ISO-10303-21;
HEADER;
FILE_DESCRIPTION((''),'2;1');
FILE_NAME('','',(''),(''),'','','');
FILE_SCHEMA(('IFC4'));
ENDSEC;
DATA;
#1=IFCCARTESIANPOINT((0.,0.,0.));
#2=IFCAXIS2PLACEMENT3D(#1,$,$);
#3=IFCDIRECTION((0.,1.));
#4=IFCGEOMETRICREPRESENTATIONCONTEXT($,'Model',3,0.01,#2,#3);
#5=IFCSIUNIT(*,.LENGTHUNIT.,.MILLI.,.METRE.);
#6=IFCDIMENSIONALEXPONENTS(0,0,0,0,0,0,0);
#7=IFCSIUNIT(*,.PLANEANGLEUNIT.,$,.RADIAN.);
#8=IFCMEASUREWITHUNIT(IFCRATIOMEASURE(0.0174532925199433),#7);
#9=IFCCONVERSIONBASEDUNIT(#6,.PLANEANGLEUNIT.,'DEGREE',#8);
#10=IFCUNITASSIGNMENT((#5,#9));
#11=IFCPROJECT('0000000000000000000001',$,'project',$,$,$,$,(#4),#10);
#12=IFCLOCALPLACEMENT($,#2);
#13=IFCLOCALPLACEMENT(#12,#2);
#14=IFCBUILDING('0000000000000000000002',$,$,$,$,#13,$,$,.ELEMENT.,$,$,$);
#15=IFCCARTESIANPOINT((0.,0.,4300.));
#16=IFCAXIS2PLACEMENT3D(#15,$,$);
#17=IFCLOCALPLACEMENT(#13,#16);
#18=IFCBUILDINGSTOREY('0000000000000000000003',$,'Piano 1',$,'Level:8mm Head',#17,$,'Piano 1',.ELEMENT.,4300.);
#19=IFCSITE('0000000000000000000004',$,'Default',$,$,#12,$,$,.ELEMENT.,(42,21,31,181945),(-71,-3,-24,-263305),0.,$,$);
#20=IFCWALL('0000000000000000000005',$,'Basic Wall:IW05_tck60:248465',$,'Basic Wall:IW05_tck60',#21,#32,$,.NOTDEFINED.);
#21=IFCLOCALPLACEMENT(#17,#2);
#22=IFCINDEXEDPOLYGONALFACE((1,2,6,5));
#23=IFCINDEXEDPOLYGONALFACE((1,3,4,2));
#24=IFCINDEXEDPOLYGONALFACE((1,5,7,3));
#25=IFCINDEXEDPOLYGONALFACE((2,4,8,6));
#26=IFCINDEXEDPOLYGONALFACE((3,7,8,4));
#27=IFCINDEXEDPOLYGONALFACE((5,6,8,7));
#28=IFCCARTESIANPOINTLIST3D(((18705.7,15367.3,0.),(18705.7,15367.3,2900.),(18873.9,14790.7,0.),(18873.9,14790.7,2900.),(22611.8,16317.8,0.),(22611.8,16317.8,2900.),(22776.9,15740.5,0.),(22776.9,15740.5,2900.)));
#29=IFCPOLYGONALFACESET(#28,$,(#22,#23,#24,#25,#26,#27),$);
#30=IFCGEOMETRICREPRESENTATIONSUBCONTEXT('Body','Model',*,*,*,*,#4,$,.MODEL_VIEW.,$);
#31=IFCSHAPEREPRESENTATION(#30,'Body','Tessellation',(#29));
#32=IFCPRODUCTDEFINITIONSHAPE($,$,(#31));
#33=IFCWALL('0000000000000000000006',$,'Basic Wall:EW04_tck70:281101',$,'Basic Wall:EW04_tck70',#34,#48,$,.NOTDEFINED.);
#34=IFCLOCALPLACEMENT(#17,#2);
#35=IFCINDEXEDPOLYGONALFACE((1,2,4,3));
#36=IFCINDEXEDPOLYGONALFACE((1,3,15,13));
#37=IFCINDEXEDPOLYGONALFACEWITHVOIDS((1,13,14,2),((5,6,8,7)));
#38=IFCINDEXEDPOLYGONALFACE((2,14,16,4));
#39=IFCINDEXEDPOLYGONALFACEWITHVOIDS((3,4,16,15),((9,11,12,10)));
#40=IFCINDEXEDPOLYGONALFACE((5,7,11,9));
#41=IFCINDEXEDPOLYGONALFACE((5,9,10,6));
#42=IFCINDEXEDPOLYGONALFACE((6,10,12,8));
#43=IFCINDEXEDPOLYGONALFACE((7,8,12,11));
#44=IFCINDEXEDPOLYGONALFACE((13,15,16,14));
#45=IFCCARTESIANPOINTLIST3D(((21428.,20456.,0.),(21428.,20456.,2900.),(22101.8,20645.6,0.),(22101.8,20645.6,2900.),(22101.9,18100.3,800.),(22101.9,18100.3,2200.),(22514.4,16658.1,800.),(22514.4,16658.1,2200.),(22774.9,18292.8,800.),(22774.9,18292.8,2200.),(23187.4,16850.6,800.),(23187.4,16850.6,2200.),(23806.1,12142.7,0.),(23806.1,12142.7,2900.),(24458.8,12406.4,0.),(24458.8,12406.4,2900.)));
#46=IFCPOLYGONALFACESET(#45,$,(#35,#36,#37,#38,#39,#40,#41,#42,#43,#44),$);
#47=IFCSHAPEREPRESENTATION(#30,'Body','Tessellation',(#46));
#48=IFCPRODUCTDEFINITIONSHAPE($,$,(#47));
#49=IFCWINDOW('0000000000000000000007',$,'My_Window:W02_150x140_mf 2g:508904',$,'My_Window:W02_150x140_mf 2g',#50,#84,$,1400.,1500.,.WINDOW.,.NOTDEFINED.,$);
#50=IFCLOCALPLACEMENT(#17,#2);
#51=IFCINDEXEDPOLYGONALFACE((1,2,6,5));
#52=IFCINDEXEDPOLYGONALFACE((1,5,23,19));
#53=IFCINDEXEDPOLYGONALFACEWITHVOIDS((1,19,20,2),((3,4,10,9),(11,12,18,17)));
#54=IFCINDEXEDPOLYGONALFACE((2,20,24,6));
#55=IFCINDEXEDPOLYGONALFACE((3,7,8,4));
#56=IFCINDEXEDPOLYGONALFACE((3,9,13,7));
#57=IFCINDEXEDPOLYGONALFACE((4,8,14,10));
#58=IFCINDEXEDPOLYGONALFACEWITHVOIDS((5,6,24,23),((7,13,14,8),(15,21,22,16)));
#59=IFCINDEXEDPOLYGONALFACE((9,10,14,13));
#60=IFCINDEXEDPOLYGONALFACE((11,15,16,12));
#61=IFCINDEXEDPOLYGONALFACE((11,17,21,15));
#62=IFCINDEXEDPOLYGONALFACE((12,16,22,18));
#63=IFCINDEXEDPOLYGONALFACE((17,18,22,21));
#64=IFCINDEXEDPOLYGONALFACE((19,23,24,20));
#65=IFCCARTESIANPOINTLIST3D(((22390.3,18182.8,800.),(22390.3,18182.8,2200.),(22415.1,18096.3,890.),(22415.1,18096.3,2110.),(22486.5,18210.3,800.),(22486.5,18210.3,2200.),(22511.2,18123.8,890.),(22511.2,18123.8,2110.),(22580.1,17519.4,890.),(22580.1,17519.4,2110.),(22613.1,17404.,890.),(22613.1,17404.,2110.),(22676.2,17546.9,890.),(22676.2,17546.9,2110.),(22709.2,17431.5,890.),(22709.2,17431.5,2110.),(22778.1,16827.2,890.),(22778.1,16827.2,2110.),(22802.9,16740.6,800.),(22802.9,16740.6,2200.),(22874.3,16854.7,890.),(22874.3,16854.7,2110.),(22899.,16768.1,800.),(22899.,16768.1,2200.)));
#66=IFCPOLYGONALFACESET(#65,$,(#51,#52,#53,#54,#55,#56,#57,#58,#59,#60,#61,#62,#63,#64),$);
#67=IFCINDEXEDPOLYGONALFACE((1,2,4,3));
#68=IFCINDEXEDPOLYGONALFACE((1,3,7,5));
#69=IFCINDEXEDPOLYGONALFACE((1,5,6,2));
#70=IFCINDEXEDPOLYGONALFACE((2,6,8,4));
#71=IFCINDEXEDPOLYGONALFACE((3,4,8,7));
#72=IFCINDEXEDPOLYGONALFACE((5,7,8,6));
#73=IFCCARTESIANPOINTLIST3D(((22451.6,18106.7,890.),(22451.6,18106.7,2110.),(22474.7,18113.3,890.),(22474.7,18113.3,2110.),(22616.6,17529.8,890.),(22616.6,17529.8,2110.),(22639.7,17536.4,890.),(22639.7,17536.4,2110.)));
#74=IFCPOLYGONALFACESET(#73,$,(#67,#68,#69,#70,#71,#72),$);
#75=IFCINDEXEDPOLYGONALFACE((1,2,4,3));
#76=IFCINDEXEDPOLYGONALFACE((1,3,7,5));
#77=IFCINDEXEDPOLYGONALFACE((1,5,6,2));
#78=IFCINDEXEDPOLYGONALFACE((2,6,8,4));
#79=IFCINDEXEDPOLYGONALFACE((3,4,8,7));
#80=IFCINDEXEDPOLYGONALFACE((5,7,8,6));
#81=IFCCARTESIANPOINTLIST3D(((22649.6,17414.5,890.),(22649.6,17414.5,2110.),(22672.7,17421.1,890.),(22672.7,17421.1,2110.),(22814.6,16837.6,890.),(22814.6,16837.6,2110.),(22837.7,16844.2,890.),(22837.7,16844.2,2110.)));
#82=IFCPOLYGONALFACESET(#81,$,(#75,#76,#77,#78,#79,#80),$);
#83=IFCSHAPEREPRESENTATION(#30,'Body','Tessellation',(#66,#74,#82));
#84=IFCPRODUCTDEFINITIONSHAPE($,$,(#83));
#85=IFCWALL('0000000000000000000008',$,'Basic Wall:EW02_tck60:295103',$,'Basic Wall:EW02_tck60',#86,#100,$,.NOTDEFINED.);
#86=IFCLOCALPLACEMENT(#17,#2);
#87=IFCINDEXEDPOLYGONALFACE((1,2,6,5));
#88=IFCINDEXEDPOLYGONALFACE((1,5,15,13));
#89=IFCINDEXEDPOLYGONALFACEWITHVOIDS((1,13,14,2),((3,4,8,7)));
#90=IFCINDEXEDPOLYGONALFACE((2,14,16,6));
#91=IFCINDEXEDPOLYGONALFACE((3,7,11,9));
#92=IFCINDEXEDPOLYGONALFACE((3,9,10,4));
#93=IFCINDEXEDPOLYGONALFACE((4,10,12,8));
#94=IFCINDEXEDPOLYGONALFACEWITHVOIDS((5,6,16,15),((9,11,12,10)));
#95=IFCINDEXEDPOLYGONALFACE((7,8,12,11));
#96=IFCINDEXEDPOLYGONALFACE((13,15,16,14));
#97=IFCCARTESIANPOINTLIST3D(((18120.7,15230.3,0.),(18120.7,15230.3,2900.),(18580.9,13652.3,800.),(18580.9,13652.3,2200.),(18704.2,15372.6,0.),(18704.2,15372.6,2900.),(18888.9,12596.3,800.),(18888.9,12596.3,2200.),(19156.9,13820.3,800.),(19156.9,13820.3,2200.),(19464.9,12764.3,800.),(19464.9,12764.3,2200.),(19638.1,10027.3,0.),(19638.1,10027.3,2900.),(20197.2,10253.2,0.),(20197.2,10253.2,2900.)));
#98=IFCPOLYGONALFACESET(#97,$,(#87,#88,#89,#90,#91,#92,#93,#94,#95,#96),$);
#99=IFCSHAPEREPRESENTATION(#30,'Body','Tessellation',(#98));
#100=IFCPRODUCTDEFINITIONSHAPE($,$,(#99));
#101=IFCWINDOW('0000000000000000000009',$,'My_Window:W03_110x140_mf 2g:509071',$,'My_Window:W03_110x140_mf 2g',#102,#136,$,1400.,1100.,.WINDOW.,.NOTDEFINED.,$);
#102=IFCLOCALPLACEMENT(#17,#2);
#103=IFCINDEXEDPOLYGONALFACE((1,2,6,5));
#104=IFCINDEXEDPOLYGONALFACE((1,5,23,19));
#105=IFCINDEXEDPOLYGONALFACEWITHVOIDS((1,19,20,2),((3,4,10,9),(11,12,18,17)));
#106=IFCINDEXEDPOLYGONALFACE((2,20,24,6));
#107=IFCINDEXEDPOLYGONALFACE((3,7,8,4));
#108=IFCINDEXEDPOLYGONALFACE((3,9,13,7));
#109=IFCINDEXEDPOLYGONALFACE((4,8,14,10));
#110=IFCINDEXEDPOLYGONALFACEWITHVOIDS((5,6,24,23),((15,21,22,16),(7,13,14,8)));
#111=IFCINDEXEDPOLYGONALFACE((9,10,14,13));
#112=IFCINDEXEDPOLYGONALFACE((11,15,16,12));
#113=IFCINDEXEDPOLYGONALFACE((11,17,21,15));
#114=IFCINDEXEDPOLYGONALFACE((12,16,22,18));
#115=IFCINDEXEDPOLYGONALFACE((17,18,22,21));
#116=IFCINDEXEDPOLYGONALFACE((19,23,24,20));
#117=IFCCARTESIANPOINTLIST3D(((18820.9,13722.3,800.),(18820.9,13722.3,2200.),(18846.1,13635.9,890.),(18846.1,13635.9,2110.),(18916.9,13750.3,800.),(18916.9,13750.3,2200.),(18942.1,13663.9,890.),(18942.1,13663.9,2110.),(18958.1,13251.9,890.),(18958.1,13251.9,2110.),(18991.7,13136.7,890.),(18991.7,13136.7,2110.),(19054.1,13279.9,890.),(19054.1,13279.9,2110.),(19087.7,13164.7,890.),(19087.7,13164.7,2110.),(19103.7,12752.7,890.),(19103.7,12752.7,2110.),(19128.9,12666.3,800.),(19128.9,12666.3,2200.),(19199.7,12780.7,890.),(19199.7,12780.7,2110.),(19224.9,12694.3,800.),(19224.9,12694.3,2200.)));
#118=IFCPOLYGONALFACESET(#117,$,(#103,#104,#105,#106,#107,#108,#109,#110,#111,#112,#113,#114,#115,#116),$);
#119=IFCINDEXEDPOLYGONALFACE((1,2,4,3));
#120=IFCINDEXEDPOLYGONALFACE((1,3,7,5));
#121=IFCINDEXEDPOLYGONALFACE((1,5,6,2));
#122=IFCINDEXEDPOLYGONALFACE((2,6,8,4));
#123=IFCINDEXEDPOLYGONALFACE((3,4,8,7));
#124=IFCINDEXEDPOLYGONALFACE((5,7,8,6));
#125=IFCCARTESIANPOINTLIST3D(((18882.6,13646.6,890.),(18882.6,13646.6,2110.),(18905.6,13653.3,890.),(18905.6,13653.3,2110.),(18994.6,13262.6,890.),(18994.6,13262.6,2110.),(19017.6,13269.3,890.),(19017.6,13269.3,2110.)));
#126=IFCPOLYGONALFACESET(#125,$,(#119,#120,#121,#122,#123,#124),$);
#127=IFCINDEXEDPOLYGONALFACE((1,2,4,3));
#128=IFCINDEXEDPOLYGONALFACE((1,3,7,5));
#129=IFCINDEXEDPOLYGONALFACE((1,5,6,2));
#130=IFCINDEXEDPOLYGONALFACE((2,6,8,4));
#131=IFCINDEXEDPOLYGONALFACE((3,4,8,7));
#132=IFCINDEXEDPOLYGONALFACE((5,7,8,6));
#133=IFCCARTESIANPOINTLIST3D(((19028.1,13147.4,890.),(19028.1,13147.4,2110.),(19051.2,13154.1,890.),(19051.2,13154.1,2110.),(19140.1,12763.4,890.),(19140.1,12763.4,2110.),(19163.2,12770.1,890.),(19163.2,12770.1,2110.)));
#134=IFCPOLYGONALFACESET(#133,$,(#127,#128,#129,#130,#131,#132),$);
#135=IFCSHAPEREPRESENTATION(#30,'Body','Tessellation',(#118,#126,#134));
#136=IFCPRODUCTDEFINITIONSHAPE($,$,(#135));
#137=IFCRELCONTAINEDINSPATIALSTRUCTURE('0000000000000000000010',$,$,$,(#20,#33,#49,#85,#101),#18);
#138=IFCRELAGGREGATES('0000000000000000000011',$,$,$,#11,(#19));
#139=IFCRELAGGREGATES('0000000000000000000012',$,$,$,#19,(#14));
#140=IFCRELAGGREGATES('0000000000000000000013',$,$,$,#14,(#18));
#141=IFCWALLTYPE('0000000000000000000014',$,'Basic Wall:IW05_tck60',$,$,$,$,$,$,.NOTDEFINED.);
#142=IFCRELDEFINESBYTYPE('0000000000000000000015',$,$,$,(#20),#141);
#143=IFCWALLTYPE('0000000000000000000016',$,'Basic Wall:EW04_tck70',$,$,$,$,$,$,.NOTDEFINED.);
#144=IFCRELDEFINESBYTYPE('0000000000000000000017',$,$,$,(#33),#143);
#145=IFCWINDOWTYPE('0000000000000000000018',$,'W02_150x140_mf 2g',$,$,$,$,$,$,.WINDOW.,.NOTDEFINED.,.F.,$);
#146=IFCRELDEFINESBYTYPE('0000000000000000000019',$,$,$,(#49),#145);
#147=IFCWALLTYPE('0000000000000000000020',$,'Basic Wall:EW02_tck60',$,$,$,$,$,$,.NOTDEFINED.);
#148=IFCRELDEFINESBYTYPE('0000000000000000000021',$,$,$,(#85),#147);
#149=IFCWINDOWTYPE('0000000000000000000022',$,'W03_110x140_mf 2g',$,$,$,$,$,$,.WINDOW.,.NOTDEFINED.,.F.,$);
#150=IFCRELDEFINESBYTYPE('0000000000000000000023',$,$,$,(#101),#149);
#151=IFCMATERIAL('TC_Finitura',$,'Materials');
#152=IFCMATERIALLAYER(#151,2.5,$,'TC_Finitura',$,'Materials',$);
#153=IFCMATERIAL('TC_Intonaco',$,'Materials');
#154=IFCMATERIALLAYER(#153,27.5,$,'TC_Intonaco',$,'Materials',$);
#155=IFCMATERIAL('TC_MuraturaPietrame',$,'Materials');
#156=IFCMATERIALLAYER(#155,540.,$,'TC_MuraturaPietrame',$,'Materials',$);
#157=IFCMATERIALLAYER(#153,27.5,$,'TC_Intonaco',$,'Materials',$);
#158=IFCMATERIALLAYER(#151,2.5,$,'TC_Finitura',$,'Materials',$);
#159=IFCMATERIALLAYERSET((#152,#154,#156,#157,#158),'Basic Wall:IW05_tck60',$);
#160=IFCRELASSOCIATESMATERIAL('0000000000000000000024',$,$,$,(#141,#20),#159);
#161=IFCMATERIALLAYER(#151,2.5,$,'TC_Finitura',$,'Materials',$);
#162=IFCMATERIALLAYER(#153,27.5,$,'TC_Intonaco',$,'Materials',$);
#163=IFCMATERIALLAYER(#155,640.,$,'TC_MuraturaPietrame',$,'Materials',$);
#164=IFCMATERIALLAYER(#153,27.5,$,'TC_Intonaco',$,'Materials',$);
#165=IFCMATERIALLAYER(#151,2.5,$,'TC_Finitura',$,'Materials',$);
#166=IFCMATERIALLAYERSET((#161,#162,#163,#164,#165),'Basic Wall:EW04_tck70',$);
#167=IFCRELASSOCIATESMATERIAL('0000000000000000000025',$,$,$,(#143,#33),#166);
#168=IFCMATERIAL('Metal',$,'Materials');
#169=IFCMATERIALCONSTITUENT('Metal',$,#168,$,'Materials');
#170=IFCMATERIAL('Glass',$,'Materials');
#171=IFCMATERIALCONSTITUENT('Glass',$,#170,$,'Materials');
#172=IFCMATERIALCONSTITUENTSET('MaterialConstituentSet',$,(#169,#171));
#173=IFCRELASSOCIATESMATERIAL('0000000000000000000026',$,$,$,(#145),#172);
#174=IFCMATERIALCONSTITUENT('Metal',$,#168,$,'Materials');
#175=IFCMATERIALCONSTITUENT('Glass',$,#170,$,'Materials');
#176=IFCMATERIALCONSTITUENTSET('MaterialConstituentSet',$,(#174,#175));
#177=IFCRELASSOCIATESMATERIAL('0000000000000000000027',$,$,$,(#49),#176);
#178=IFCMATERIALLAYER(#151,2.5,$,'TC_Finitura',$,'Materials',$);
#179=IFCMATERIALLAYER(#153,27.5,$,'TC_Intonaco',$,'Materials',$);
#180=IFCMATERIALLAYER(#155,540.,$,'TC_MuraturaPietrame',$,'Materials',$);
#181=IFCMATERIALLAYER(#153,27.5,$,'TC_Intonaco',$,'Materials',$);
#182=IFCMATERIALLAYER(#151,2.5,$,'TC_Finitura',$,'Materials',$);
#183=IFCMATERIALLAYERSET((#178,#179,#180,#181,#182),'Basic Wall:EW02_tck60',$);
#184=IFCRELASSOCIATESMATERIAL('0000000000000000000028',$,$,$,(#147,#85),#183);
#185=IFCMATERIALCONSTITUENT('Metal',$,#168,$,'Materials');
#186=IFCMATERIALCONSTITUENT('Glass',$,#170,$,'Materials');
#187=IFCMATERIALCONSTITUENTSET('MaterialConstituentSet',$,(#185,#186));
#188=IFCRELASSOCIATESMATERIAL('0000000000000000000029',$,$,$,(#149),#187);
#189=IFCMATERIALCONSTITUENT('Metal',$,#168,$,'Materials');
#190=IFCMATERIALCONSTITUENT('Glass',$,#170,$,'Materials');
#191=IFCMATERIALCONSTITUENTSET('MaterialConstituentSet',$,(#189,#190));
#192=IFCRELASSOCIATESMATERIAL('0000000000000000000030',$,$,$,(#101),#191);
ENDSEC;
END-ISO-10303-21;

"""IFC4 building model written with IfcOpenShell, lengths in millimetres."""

from ifc_helpers import new_model, entity, si_unit, converted_unit, direction, frame, frame_2d, origin, origin_2d_with_axis, place, context, subcontext, project, spatial, polyline, rectangle, outline, extrude, clip, bounded_halfspace, source, transform, mapped, material, layer, layer_set, layer_usage, constituent, constituent_set, type_object, type_shapes, element, fill, save


model = new_model("IFC4")

# Units and contexts
model_context = context("Model", 3, precision=0.01, world=origin(), true_north=direction((0.0, 1.0)))
body_context = subcontext(model_context, "Body", "Model", "MODEL_VIEW")
ifc_project = project(units=[si_unit("LENGTHUNIT", "METRE", prefix="MILLI"), converted_unit("PLANEANGLEUNIT", "DEGREE", entity("IfcRatioMeasure", 0.0174532925199433), si_unit("PLANEANGLEUNIT", "RADIAN"), dimensions=[0, 0, 0, 0, 0, 0, 0])], contexts=[model_context])

# Site, building, storey
site_placement = place(None, origin())
site = spatial("IfcSite", under=ifc_project, at=site_placement, Name="Default", CompositionType="ELEMENT", RefLatitude=(42, 21, 31, 181945), RefLongitude=(-71, -3, -24, -263305), RefElevation=0.0)
building_placement = place(site_placement, origin())
building = spatial("IfcBuilding", under=site, at=building_placement, CompositionType="ELEMENT")
storey_placement = place(building_placement, frame((0.0, 0.0, 4300.0)))
storey = spatial("IfcBuildingStorey", under=building, at=storey_placement, Name="Piano 1", ObjectType="Level:8mm Head", LongName="Piano 1", CompositionType="ELEMENT", Elevation=4300.0)

# Wall
ifc_material_1 = material(Name="TC_Finitura", Category="Materials")
ifc_layer_1 = layer(ifc_material_1, 2.5, Name="TC_Finitura", Category="Materials")
ifc_material_2 = material(Name="TC_Intonaco", Category="Materials")
ifc_layer_2 = layer(ifc_material_2, 27.5, Name="TC_Intonaco", Category="Materials")
ifc_material_3 = material(Name="TC_MuraturaPietrame", Category="Materials")
ifc_layer_3 = layer(ifc_material_3, 540.0, Name="TC_MuraturaPietrame", Category="Materials")
ifc_layer_4 = layer(ifc_material_2, 27.5, Name="TC_Intonaco", Category="Materials")
ifc_layer_5 = layer(ifc_material_1, 2.5, Name="TC_Finitura", Category="Materials")
ifc_layer_set_1 = layer_set([ifc_layer_1, ifc_layer_2, ifc_layer_3, ifc_layer_4, ifc_layer_5], Name="Basic Wall:IW05_tck60")
ifc_layer_usage_1 = layer_usage(ifc_layer_set_1, "AXIS2", "NEGATIVE", 300.0)
wall_type_1 = type_object("IfcWallType", Name="Basic Wall:IW05_tck60", PredefinedType="NOTDEFINED", material=ifc_layer_set_1)
wall_1_placement = place(storey_placement, frame((22706.0, 16032.0, 0.0), z_axis=(0.0, 0.0, 1.0), x_axis=(-0.971642, -0.236458, 0.0)))
element("IfcWall", 1, at=wall_1_placement, inside=storey, type_object=wall_type_1, material=ifc_layer_usage_1, Name="Basic Wall:IW05_tck60:248465", ObjectType="Basic Wall:IW05_tck60", PredefinedType="NOTDEFINED", context=body_context, shape_type="Clipping", body=[
    clip(extrude(outline(polyline([(4044.0, -300.0), (4016.9, 300.0), (0.0, 300.0), (24.0, -300.0), (4044.0, -300.0)])), origin(), (0.0, 0.0, 1.0), 2900.0), bounded_halfspace(frame((24.0, -300.0, 2900.0), z_axis=(0.0, 0.0, -1.0), x_axis=(-0.999371, -0.035464, 0.0)), True, frame((24.0, -300.0, 2900.0)), polyline([(0.0, 0.0), (4020.0, 0.0), (3993.0, 600.0), (-24.0, 600.0), (0.0, 0.0)]))),
])

# Walls, openings, windows
ifc_layer_6 = layer(ifc_material_1, 2.5, Name="TC_Finitura", Category="Materials")
ifc_layer_7 = layer(ifc_material_2, 27.5, Name="TC_Intonaco", Category="Materials")
ifc_layer_8 = layer(ifc_material_3, 640.0, Name="TC_MuraturaPietrame", Category="Materials")
ifc_layer_9 = layer(ifc_material_2, 27.5, Name="TC_Intonaco", Category="Materials")
ifc_layer_10 = layer(ifc_material_1, 2.5, Name="TC_Finitura", Category="Materials")
ifc_layer_set_2 = layer_set([ifc_layer_6, ifc_layer_7, ifc_layer_8, ifc_layer_9, ifc_layer_10], Name="Basic Wall:EW04_tck70")
ifc_layer_usage_2 = layer_usage(ifc_layer_set_2, "AXIS2", "NEGATIVE", 350.0)
wall_type_2 = type_object("IfcWallType", Name="Basic Wall:EW04_tck70", PredefinedType="NOTDEFINED", material=ifc_layer_set_2)
wall_2_placement = place(storey_placement, frame((24142.6, 12239.0, 0.0), z_axis=(0.0, 0.0, 1.0), x_axis=(-0.275033, 0.961435, 0.0)))
wall_2 = element("IfcWall", 2, at=wall_2_placement, inside=storey, type_object=wall_type_2, material=ifc_layer_usage_2, Name="Basic Wall:EW04_tck70:281101", ObjectType="Basic Wall:EW04_tck70", PredefinedType="NOTDEFINED", context=body_context, shape_type="Clipping", body=[
    clip(extrude(outline(polyline([(8643.6, -350.0), (8646.7, 350.0), (8246.7, 350.0), (4342.6, 350.0), (3742.1, 350.0), (0.0, 350.0), (74.0, -350.0), (8643.6, -350.0)])), origin(), (0.0, 0.0, 1.0), 2900.0), bounded_halfspace(frame((74.0, -350.0, 2900.0), z_axis=(0.0, 0.0, -1.0), x_axis=(-0.004433, -0.99999, 0.0)), True, frame((74.0, -350.0, 2900.0)), polyline([(0.0, 0.0), (8569.6, 0.0), (8572.7, 700.0), (8172.7, 700.0), (4268.6, 700.0), (3668.1, 700.0), (-74.0, 700.0), (0.0, 0.0)]))),
])
opening_1_placement = place(wall_2_placement, frame((6196.5, 350.0, 800.0)))
opening_1 = element("IfcOpeningElement", 3, at=opening_1_placement, cuts=wall_2, ObjectType="Opening", PredefinedType="OPENING", context=body_context, shape_type="SweptSolid", body=[
    extrude(rectangle(XDim=1400.0, YDim=1500.0, at=frame_2d((700.0, 750.0), x_axis=(-1.0, 0.0))), frame((0.0, 0.0, 0.0), z_axis=(0.0, -1.0, 0.0), x_axis=(0.0, 0.0, 1.0)), (0.0, 0.0, 1.0), 700.0),
])
ifc_material_4 = material(Name="Metal", Category="Materials")
ifc_constituent_1 = constituent(ifc_material_4, Name="Metal", Category="Materials")
ifc_material_5 = material(Name="Glass", Category="Materials")
ifc_constituent_2 = constituent(ifc_material_5, Name="Glass", Category="Materials")
ifc_constituent_set_1 = constituent_set(constituents=[ifc_constituent_1, ifc_constituent_2], Name="MaterialConstituentSet")
ifc_constituent_3 = constituent(ifc_material_4, Name="Metal", Category="Materials")
ifc_constituent_4 = constituent(ifc_material_5, Name="Glass", Category="Materials")
ifc_constituent_set_2 = constituent_set(constituents=[ifc_constituent_3, ifc_constituent_4], Name="MaterialConstituentSet")
window_type_1 = type_object("IfcWindowType", Name="W02_150x140_mf 2g", ParameterTakesPrecedence=False, PartitioningType="NOTDEFINED", PredefinedType="WINDOW", material=ifc_constituent_set_2)
shared_shape_1 = source(origin(), body_context, "Body", "SweptSolid", [
    extrude(outline(polyline([(-750.0, -700.0), (750.0, -700.0), (750.0, 700.0), (-750.0, 700.0), (-750.0, -700.0)]), holes=[polyline([(-60.0, -610.0), (-660.0, -610.0), (-660.0, 610.0), (-60.0, 610.0), (-60.0, -610.0)]), polyline([(660.0, -610.0), (60.0, -610.0), (60.0, 610.0), (660.0, 610.0), (660.0, -610.0)])]), frame((750.0, 300.0, 700.0), z_axis=(0.0, 1.0, 0.0), x_axis=(1.0, 0.0, 0.0)), (0.0, 0.0, 1.0), 100.0),
    extrude(rectangle(XDim=24.0, YDim=600.0, at=origin_2d_with_axis()), frame((390.0, 350.0, 90.0), z_axis=(0.0, 0.0, 1.0), x_axis=(0.0, 1.0, 0.0)), (0.0, 0.0, 1.0), 1220.0),
    extrude(rectangle(XDim=24.0, YDim=600.0, at=frame_2d((0.0, 0.0), x_axis=(1.0, 0.0))), frame((1110.0, 350.0, 90.0), z_axis=(0.0, 0.0, 1.0), x_axis=(0.0, 1.0, 0.0)), (0.0, 0.0, 1.0), 1220.0),
])
type_shapes(window_type_1, [shared_shape_1])
window_1_placement = place(opening_1_placement, frame((0.0, 0.0, 0.0), z_axis=(0.0, 0.0, 1.0), x_axis=(-1.0, 0.0, 0.0)))
window_1 = element("IfcWindow", 4, at=window_1_placement, inside=storey, type_object=window_type_1, material=ifc_constituent_set_1, Name="My_Window:W02_150x140_mf 2g:508904", ObjectType="My_Window:W02_150x140_mf 2g", OverallHeight=1400.0, OverallWidth=1500.0, PartitioningType="NOTDEFINED", PredefinedType="WINDOW", context=body_context, shape_type="MappedRepresentation", body=[
    mapped(shared_shape_1, transform((0.0, 0.0, 0.0), scale=1.0)),
])
fill(opening_1, window_1)
ifc_layer_11 = layer(ifc_material_1, 2.5, Name="TC_Finitura", Category="Materials")
ifc_layer_12 = layer(ifc_material_2, 27.5, Name="TC_Intonaco", Category="Materials")
ifc_layer_13 = layer(ifc_material_3, 540.0, Name="TC_MuraturaPietrame", Category="Materials")
ifc_layer_14 = layer(ifc_material_2, 27.5, Name="TC_Intonaco", Category="Materials")
ifc_layer_15 = layer(ifc_material_1, 2.5, Name="TC_Finitura", Category="Materials")
ifc_layer_set_3 = layer_set([ifc_layer_11, ifc_layer_12, ifc_layer_13, ifc_layer_14, ifc_layer_15], Name="Basic Wall:EW02_tck60")
ifc_layer_usage_3 = layer_usage(ifc_layer_set_3, "AXIS2", "POSITIVE", -300.0)
wall_type_3 = type_object("IfcWallType", Name="Basic Wall:EW02_tck60", PredefinedType="NOTDEFINED", material=ifc_layer_set_3)
wall_3_placement = place(storey_placement, frame((18408.7, 15314.3, 0.0), z_axis=(0.0, 0.0, 1.0), x_axis=(0.279974, -0.960008, 0.0)))
wall_3 = element("IfcWall", 5, at=wall_3_placement, inside=storey, type_object=wall_type_3, material=ifc_layer_usage_3, Name="Basic Wall:EW02_tck60:295103", ObjectType="Basic Wall:EW02_tck60", PredefinedType="NOTDEFINED", context=body_context, shape_type="Clipping", body=[
    clip(extrude(outline(polyline([(5419.7, -300.0), (5359.4, 300.0), (4957.4, 300.0), (632.9, 300.0), (32.3, 300.0), (26.7, 300.0), (24.2, 243.1), (1.9, -256.7), (0.0, -300.0), (600.6, -300.0), (5012.3, -300.0), (5419.7, -300.0)])), origin(), (0.0, 0.0, 1.0), 2900.0), bounded_halfspace(frame((0.0, -300.0, 2900.0), z_axis=(0.0, 0.0, -1.0), x_axis=(0.009577, 0.999954, 0.0)), True, frame((0.0, -300.0, 2900.0)), polyline([(0.0, 0.0), (600.6, 0.0), (602.5, 0.0), (5012.3, 0.0), (5419.7, 0.0), (5359.4, 600.0), (4957.4, 600.0), (632.9, 600.0), (32.3, 600.0), (26.7, 600.0), (24.2, 543.1), (1.9, 43.3), (0.0, 0.0)]))),
])
opening_2_placement = place(wall_3_placement, frame((1643.7, -300.0, 800.0)))
opening_2 = element("IfcOpeningElement", 6, at=opening_2_placement, cuts=wall_3, ObjectType="Opening", PredefinedType="OPENING", context=body_context, shape_type="SweptSolid", body=[
    extrude(rectangle(XDim=1400.0, YDim=1100.0, at=frame_2d((700.0, 550.0), x_axis=(-1.0, 0.0))), frame((0.0, 0.0, 0.0), z_axis=(0.0, 1.0, 0.0), x_axis=(0.0, 0.0, 1.0)), (0.0, 0.0, 1.0), 600.0),
])
ifc_constituent_5 = constituent(ifc_material_4, Name="Metal", Category="Materials")
ifc_constituent_6 = constituent(ifc_material_5, Name="Glass", Category="Materials")
ifc_constituent_set_3 = constituent_set(constituents=[ifc_constituent_5, ifc_constituent_6], Name="MaterialConstituentSet")
ifc_constituent_7 = constituent(ifc_material_4, Name="Metal", Category="Materials")
ifc_constituent_8 = constituent(ifc_material_5, Name="Glass", Category="Materials")
ifc_constituent_set_4 = constituent_set(constituents=[ifc_constituent_7, ifc_constituent_8], Name="MaterialConstituentSet")
window_type_2 = type_object("IfcWindowType", Name="W03_110x140_mf 2g", ParameterTakesPrecedence=False, PartitioningType="NOTDEFINED", PredefinedType="WINDOW", material=ifc_constituent_set_4)
shared_shape_2 = source(origin(), body_context, "Body", "SweptSolid", [
    extrude(outline(polyline([(-550.0, -700.0), (550.0, -700.0), (550.0, 700.0), (-550.0, 700.0), (-550.0, -700.0)]), holes=[polyline([(-60.0, -610.0), (-460.0, -610.0), (-460.0, 610.0), (-60.0, 610.0), (-60.0, -610.0)]), polyline([(460.0, -610.0), (60.0, -610.0), (60.0, 610.0), (460.0, 610.0), (460.0, -610.0)])]), frame((550.0, 250.0, 700.0), z_axis=(0.0, 1.0, 0.0), x_axis=(1.0, 0.0, 0.0)), (0.0, 0.0, 1.0), 100.0),
    extrude(rectangle(XDim=24.0, YDim=400.0, at=origin_2d_with_axis()), frame((290.0, 300.0, 90.0), z_axis=(0.0, 0.0, 1.0), x_axis=(0.0, 1.0, 0.0)), (0.0, 0.0, 1.0), 1220.0),
    extrude(rectangle(XDim=24.0, YDim=400.0, at=frame_2d((0.0, 0.0), x_axis=(1.0, 0.0))), frame((810.0, 300.0, 90.0), z_axis=(0.0, 0.0, 1.0), x_axis=(0.0, 1.0, 0.0)), (0.0, 0.0, 1.0), 1220.0),
])
type_shapes(window_type_2, [shared_shape_2])
window_2_placement = place(opening_2_placement, origin())
window_2 = element("IfcWindow", 7, at=window_2_placement, inside=storey, type_object=window_type_2, material=ifc_constituent_set_3, Name="My_Window:W03_110x140_mf 2g:509071", ObjectType="My_Window:W03_110x140_mf 2g", OverallHeight=1400.0, OverallWidth=1100.0, PartitioningType="NOTDEFINED", PredefinedType="WINDOW", context=body_context, shape_type="MappedRepresentation", body=[
    mapped(shared_shape_2, transform((0.0, 0.0, 0.0), scale=1.0)),
])
fill(opening_2, window_2)

save(model, "model.ifc")
